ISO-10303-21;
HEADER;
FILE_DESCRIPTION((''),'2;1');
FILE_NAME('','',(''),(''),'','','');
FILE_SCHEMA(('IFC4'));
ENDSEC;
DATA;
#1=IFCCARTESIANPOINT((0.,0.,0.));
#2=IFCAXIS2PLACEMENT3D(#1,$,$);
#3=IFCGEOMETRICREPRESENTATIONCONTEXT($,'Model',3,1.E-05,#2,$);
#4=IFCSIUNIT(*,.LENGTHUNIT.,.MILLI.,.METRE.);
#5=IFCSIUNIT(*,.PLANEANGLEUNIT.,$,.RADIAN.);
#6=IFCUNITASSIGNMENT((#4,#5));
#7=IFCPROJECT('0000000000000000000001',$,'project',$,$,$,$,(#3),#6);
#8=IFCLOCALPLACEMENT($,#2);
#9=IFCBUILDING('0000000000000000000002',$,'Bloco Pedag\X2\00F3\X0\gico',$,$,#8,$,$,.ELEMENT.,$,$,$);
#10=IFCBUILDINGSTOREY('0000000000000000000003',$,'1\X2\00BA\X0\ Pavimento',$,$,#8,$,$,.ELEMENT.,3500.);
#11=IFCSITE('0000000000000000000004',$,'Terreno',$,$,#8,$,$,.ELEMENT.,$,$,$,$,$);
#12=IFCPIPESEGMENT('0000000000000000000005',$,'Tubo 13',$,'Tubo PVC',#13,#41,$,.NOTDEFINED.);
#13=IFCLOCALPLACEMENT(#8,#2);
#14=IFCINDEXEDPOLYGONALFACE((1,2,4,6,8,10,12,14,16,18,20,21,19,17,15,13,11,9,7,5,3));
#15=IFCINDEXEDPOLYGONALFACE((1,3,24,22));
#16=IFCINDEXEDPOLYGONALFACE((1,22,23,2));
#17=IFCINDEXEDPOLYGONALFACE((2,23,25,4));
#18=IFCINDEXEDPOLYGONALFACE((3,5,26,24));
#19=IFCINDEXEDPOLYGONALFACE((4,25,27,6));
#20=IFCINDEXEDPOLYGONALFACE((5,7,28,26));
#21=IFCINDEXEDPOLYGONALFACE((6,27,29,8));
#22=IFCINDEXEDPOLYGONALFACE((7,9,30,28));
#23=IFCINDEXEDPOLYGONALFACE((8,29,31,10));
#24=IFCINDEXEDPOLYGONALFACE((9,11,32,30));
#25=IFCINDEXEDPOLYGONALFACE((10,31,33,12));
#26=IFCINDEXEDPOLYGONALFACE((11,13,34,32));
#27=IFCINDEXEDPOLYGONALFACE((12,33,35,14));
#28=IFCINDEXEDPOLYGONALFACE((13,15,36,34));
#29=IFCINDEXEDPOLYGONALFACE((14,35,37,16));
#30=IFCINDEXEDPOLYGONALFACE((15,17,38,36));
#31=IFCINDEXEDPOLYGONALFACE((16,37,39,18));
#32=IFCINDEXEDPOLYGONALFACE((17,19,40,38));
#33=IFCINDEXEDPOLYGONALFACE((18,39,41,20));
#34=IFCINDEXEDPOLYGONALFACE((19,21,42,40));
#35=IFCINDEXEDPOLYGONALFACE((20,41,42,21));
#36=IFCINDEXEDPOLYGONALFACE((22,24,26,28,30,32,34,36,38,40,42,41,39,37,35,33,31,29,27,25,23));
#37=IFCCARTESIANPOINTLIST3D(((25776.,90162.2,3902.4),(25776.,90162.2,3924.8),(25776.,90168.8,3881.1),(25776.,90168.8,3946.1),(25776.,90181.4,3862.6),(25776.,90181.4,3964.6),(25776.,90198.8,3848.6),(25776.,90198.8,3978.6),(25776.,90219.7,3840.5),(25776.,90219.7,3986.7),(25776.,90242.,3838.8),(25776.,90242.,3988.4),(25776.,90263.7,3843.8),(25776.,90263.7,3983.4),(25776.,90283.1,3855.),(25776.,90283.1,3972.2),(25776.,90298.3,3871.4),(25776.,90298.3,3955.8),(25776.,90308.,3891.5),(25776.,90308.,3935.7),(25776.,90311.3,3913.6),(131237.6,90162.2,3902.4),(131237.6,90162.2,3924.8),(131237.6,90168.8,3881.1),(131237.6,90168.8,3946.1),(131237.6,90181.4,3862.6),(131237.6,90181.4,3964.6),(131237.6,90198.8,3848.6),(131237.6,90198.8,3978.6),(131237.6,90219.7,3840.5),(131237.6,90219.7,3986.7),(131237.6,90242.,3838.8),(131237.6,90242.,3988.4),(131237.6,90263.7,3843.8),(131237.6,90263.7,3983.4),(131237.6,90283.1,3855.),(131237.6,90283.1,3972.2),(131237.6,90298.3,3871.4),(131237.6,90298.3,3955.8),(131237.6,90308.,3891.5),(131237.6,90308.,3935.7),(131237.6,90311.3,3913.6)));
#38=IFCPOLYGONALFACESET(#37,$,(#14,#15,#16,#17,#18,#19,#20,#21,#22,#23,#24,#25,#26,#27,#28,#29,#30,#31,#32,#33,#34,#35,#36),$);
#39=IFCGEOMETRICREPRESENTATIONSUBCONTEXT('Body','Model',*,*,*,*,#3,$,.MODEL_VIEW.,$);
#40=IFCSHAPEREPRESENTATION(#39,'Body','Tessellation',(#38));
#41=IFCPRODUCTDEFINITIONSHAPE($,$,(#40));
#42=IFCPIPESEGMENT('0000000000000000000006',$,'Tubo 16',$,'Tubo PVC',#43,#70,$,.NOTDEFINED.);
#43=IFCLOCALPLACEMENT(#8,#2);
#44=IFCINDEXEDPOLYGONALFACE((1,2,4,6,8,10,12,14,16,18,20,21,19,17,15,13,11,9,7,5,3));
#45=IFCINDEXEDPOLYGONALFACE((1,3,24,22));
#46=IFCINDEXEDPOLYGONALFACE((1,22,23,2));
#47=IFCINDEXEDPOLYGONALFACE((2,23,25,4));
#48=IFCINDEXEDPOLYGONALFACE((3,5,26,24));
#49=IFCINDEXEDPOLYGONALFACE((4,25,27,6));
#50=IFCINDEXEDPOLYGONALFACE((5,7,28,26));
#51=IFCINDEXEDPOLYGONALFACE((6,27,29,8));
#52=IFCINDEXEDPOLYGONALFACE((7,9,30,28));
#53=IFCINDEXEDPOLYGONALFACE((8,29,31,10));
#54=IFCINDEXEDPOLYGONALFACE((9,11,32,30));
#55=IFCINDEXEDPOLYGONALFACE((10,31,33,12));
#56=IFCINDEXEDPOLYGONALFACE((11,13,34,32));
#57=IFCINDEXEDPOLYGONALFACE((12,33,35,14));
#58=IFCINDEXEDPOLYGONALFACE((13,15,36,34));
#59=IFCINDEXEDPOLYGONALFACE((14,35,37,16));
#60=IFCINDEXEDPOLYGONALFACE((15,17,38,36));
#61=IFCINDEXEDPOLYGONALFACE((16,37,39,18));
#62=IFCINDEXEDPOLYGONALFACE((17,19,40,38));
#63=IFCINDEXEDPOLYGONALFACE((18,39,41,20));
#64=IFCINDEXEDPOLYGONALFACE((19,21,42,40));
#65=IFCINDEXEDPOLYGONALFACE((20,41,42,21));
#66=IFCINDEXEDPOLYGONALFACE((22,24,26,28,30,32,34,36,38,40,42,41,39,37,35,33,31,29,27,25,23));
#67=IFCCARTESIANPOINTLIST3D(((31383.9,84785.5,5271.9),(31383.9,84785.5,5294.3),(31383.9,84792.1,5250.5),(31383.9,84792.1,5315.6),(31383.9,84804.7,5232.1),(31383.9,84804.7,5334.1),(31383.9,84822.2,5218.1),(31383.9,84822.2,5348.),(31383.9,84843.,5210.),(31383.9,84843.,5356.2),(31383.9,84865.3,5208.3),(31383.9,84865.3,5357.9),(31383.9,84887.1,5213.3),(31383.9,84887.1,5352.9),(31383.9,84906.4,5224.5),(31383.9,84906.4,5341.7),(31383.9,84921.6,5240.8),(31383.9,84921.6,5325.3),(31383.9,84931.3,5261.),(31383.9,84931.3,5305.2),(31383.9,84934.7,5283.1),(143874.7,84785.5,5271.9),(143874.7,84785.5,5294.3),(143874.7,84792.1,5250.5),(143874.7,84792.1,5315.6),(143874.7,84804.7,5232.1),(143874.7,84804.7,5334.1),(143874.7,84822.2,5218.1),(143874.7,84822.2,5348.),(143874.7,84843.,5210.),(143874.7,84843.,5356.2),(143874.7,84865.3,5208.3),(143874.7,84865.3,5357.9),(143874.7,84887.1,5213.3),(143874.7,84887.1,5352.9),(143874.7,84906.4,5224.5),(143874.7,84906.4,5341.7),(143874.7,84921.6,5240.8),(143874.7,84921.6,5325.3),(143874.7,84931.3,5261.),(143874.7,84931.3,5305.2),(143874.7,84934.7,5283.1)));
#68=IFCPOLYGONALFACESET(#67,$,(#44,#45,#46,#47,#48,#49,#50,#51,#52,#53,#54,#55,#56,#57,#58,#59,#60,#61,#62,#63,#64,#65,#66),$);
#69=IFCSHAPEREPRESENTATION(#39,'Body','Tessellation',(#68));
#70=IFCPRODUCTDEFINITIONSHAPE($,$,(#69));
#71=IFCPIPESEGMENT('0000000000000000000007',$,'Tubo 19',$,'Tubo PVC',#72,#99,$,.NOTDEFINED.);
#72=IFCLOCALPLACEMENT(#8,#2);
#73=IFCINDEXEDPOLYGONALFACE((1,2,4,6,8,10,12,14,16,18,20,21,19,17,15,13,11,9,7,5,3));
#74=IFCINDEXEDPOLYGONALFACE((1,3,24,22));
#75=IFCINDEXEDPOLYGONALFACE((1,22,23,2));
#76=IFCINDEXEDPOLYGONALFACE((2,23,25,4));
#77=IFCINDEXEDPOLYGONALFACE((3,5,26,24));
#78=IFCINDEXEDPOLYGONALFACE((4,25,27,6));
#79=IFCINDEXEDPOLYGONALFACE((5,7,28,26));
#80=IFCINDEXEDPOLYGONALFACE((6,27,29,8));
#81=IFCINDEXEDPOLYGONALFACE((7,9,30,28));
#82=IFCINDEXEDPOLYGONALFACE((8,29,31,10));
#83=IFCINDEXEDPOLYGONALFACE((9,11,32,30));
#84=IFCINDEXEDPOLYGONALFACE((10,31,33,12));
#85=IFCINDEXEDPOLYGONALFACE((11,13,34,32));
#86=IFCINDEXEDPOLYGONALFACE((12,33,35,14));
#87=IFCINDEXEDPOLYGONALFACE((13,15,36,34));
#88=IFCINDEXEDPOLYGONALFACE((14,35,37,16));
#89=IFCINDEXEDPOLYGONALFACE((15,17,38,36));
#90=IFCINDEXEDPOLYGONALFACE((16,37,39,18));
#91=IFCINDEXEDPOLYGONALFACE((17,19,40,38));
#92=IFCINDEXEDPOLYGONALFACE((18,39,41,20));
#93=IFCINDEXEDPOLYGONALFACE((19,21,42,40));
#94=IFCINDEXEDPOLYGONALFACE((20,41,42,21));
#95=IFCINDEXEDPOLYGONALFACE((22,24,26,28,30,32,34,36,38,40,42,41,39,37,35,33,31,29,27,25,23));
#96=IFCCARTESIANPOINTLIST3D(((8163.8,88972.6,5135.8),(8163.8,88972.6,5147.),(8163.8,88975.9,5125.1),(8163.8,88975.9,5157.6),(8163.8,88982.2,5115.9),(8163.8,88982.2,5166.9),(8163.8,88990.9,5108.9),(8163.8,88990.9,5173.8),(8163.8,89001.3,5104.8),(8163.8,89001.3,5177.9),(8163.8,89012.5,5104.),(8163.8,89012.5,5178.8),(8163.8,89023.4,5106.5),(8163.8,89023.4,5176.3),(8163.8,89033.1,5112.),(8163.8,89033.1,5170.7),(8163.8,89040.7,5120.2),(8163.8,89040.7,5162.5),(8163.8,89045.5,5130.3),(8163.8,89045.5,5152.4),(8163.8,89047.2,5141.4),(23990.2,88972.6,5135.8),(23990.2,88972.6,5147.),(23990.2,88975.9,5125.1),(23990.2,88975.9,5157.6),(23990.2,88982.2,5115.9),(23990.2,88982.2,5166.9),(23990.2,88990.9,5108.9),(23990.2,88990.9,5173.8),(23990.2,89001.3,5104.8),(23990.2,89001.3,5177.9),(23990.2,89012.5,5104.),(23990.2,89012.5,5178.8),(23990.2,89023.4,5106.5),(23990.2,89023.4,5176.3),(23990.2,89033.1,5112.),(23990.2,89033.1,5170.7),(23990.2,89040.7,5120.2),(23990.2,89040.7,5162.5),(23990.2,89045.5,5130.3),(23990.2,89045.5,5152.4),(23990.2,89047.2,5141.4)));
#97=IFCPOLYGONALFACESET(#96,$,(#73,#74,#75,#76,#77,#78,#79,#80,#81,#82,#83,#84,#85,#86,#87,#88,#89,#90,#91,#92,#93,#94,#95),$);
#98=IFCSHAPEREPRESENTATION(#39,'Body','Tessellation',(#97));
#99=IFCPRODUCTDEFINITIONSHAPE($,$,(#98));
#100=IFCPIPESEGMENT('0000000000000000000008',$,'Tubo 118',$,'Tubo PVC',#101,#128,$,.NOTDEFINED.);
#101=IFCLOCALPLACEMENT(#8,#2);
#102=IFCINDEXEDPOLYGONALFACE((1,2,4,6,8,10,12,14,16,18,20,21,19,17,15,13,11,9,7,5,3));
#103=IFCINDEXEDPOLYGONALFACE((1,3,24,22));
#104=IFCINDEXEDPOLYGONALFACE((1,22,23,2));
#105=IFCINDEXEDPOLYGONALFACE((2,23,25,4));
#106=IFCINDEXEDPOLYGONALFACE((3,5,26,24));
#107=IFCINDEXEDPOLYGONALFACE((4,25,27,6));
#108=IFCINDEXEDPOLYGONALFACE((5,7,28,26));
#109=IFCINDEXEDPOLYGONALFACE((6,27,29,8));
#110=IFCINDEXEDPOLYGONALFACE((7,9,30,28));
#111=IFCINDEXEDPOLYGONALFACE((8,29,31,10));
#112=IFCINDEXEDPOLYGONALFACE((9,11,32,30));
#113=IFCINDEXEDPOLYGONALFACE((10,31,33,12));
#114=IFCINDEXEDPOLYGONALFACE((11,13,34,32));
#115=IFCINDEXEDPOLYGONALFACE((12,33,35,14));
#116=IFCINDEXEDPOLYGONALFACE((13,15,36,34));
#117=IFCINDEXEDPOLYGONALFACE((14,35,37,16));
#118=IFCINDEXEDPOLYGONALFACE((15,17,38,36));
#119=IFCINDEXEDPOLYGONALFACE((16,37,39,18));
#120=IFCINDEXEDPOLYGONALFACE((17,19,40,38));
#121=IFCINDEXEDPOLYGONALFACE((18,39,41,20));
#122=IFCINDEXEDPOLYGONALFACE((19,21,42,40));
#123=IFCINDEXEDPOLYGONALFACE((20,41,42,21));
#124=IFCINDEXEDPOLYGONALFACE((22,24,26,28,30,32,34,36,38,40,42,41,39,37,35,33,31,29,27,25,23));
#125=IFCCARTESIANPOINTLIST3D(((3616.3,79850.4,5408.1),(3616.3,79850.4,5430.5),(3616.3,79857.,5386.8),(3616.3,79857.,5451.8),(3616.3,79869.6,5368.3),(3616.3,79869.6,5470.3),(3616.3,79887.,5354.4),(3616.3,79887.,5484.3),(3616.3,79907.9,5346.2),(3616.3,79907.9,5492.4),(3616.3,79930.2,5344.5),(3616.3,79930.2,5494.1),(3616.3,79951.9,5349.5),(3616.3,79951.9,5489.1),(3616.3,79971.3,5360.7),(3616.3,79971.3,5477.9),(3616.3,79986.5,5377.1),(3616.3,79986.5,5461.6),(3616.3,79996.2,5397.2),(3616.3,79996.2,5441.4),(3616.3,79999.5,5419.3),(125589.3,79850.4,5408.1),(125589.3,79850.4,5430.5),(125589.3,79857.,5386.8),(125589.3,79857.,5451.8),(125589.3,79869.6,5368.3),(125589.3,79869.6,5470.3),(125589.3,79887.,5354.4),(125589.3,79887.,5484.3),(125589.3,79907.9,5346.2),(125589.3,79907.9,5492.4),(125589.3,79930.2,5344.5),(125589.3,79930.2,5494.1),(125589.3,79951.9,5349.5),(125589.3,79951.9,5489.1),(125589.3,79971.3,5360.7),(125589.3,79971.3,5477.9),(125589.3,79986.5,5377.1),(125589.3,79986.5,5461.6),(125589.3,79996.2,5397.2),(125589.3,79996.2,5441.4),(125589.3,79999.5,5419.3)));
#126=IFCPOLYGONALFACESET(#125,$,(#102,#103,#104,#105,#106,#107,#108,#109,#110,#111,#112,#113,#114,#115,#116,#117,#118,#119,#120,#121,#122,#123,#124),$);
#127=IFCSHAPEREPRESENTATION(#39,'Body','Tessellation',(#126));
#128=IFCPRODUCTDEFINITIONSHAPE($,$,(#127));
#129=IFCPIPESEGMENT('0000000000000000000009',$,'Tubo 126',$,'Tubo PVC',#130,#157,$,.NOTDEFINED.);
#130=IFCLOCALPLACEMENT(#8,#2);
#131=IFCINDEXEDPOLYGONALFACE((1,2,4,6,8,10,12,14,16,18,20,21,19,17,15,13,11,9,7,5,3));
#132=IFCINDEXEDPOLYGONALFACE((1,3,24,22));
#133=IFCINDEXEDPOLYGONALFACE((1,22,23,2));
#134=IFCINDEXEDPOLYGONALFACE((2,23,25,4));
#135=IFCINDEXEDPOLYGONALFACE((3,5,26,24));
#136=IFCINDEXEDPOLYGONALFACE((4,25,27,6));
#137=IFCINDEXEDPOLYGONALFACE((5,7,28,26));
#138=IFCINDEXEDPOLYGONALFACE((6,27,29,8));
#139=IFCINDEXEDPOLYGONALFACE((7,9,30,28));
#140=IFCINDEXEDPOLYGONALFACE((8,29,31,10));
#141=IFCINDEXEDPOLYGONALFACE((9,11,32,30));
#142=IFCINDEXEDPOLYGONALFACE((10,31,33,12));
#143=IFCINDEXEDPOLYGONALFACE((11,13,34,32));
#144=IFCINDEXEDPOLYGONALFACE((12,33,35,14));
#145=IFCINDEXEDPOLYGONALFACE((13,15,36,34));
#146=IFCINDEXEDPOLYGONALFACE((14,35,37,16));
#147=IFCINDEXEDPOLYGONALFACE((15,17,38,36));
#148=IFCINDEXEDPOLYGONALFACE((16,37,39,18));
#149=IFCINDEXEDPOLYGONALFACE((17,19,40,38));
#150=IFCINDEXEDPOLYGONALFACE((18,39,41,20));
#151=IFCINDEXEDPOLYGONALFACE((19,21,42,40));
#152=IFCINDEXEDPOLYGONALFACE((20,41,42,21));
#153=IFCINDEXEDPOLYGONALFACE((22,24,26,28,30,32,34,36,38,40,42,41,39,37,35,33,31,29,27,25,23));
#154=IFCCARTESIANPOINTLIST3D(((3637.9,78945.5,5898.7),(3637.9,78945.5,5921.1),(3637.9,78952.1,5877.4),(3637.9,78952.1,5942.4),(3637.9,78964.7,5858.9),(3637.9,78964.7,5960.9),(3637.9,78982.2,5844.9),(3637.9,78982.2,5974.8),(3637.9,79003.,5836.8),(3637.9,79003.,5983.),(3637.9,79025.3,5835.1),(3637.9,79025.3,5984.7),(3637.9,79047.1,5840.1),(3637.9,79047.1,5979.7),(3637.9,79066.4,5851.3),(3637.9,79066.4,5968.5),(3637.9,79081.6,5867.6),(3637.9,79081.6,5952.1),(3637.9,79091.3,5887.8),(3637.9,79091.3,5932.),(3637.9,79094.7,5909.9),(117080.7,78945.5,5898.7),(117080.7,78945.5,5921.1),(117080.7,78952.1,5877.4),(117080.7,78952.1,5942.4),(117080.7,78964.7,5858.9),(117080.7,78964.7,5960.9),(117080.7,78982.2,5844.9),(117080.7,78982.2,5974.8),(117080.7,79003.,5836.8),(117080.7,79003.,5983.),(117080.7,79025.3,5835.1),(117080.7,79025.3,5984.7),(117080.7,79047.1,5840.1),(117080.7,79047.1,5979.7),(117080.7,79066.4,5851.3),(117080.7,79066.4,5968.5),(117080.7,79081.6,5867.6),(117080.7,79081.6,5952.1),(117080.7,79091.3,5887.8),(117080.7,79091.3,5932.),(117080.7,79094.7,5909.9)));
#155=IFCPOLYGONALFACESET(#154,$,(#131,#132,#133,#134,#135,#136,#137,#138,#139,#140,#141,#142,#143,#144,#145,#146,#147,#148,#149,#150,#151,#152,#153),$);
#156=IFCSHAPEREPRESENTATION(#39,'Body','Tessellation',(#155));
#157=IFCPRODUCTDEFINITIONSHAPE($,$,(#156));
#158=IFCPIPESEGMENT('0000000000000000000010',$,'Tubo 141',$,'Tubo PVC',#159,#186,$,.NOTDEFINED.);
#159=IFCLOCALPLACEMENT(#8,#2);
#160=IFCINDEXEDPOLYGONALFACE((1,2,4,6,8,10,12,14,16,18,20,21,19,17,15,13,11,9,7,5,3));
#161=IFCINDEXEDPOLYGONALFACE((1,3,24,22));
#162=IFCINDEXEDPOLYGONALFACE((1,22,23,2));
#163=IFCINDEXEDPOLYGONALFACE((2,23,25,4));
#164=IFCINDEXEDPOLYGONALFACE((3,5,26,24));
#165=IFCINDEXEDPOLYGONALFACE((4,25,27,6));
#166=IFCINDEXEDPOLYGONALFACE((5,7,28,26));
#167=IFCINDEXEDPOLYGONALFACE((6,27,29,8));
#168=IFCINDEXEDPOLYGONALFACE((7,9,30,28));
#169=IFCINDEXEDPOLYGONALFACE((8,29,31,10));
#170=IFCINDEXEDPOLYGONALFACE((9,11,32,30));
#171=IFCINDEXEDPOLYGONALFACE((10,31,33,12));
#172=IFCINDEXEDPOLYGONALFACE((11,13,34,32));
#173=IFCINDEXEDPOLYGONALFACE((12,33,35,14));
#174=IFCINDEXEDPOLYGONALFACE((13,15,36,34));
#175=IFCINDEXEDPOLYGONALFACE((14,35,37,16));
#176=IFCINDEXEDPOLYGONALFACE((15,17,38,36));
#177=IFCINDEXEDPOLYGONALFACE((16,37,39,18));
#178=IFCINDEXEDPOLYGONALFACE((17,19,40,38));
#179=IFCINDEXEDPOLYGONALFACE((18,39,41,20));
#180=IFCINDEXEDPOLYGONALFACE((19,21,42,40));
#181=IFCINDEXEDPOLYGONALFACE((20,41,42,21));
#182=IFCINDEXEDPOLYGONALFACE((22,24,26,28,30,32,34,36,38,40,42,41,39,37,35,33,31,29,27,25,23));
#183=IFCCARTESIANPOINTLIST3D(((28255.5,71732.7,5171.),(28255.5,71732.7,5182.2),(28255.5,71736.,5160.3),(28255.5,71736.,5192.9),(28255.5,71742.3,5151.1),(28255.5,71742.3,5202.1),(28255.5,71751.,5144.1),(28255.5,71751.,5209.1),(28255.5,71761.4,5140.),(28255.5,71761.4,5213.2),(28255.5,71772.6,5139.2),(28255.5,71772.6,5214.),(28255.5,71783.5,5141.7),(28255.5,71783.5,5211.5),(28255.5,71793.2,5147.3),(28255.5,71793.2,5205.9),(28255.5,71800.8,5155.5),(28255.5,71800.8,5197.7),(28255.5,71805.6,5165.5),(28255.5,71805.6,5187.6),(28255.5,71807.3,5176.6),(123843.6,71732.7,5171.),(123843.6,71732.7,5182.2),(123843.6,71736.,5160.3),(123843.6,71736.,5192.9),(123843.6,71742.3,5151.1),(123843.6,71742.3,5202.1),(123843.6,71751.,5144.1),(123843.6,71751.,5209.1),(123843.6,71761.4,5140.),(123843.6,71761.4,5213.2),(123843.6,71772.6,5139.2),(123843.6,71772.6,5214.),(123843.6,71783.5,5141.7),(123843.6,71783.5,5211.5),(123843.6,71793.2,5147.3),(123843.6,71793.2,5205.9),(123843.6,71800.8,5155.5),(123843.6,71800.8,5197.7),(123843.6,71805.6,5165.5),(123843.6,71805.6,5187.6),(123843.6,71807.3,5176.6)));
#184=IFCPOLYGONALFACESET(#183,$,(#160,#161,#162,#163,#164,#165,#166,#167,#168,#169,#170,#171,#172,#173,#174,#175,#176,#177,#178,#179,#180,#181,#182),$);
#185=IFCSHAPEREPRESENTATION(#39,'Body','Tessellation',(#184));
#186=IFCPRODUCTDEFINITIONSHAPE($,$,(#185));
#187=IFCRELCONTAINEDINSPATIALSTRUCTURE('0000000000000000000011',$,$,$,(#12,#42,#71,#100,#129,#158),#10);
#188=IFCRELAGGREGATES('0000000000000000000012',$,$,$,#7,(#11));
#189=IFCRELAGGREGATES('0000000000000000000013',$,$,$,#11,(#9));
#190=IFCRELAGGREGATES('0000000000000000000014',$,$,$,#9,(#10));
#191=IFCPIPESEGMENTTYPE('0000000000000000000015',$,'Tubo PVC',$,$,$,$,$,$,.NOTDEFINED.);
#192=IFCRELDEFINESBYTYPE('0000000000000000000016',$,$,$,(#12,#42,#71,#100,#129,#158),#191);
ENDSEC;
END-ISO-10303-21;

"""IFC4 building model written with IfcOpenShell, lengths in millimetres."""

from ifc_helpers import new_model, si_unit, frame, origin, origin_2d, place, context, subcontext, project, spatial, circle, extrude, type_object, element, save


model = new_model("IFC4")

# Units and contexts
model_context = context("Model", 3, precision=1e-05, world=origin())
body_context = subcontext(model_context, "Body", "Model", "MODEL_VIEW")
ifc_project = project(units=[si_unit("LENGTHUNIT", "METRE", prefix="MILLI"), si_unit("PLANEANGLEUNIT", "RADIAN")], contexts=[model_context])

# Site, building, storey
placement = place(None, origin())
site = spatial("IfcSite", under=ifc_project, at=placement, Name="Terreno", CompositionType="ELEMENT")
building = spatial("IfcBuilding", under=site, at=placement, Name="Bloco Pedagógico", CompositionType="ELEMENT")
storey = spatial("IfcBuildingStorey", under=building, at=placement, Name="1º Pavimento", CompositionType="ELEMENT", Elevation=3500.0)

# Pipe segments
pipe_segment_type = type_object("IfcPipeSegmentType", Name="Tubo PVC", PredefinedType="NOTDEFINED")
pipe_segment_1_placement = place(None, frame((25776.0, 90236.3, 3913.6), z_axis=(1.0, 0.0, 0.0), x_axis=(0.0, 1.0, 0.0)))
element("IfcPipeSegment", 1, at=pipe_segment_1_placement, inside=storey, type_object=pipe_segment_type, Name="Tubo 13", ObjectType="Tubo PVC", PredefinedType="NOTDEFINED", context=body_context, shape_type="SweptSolid", body=[
    extrude(circle(Radius=75.0, at=origin_2d()), None, (0.0, 0.0, 1.0), 105461.6),
])
pipe_segment_2_placement = place(None, frame((31383.9, 84859.7, 5283.1), z_axis=(1.0, 0.0, 0.0), x_axis=(0.0, 1.0, 0.0)))
element("IfcPipeSegment", 2, at=pipe_segment_2_placement, inside=storey, type_object=pipe_segment_type, Name="Tubo 16", ObjectType="Tubo PVC", PredefinedType="NOTDEFINED", context=body_context, shape_type="SweptSolid", body=[
    extrude(circle(Radius=75.0, at=origin_2d()), None, (0.0, 0.0, 1.0), 112490.8),
])
pipe_segment_3_placement = place(None, frame((8163.8, 89009.7, 5141.4), z_axis=(1.0, 0.0, 0.0), x_axis=(0.0, 1.0, 0.0)))
element("IfcPipeSegment", 3, at=pipe_segment_3_placement, inside=storey, type_object=pipe_segment_type, Name="Tubo 19", ObjectType="Tubo PVC", PredefinedType="NOTDEFINED", context=body_context, shape_type="SweptSolid", body=[
    extrude(circle(Radius=37.5, at=origin_2d()), None, (0.0, 0.0, 1.0), 15826.4),
])
pipe_segment_4_placement = place(None, frame((3616.3, 79924.5, 5419.3), z_axis=(1.0, 0.0, 0.0), x_axis=(0.0, 1.0, 0.0)))
element("IfcPipeSegment", 4, at=pipe_segment_4_placement, inside=storey, type_object=pipe_segment_type, Name="Tubo 118", ObjectType="Tubo PVC", PredefinedType="NOTDEFINED", context=body_context, shape_type="SweptSolid", body=[
    extrude(circle(Radius=75.0, at=origin_2d()), None, (0.0, 0.0, 1.0), 121973.0),
])
pipe_segment_5_placement = place(None, frame((3637.9, 79019.7, 5909.9), z_axis=(1.0, 0.0, 0.0), x_axis=(0.0, 1.0, 0.0)))
element("IfcPipeSegment", 5, at=pipe_segment_5_placement, inside=storey, type_object=pipe_segment_type, Name="Tubo 126", ObjectType="Tubo PVC", PredefinedType="NOTDEFINED", context=body_context, shape_type="SweptSolid", body=[
    extrude(circle(Radius=75.0, at=origin_2d()), None, (0.0, 0.0, 1.0), 113442.8),
])
pipe_segment_6_placement = place(None, frame((28255.5, 71769.8, 5176.6), z_axis=(1.0, 0.0, 0.0), x_axis=(0.0, 1.0, 0.0)))
element("IfcPipeSegment", 6, at=pipe_segment_6_placement, inside=storey, type_object=pipe_segment_type, Name="Tubo 141", ObjectType="Tubo PVC", PredefinedType="NOTDEFINED", context=body_context, shape_type="SweptSolid", body=[
    extrude(circle(Radius=37.5, at=origin_2d()), None, (0.0, 0.0, 1.0), 95588.1),
])

save(model, "model.ifc")
